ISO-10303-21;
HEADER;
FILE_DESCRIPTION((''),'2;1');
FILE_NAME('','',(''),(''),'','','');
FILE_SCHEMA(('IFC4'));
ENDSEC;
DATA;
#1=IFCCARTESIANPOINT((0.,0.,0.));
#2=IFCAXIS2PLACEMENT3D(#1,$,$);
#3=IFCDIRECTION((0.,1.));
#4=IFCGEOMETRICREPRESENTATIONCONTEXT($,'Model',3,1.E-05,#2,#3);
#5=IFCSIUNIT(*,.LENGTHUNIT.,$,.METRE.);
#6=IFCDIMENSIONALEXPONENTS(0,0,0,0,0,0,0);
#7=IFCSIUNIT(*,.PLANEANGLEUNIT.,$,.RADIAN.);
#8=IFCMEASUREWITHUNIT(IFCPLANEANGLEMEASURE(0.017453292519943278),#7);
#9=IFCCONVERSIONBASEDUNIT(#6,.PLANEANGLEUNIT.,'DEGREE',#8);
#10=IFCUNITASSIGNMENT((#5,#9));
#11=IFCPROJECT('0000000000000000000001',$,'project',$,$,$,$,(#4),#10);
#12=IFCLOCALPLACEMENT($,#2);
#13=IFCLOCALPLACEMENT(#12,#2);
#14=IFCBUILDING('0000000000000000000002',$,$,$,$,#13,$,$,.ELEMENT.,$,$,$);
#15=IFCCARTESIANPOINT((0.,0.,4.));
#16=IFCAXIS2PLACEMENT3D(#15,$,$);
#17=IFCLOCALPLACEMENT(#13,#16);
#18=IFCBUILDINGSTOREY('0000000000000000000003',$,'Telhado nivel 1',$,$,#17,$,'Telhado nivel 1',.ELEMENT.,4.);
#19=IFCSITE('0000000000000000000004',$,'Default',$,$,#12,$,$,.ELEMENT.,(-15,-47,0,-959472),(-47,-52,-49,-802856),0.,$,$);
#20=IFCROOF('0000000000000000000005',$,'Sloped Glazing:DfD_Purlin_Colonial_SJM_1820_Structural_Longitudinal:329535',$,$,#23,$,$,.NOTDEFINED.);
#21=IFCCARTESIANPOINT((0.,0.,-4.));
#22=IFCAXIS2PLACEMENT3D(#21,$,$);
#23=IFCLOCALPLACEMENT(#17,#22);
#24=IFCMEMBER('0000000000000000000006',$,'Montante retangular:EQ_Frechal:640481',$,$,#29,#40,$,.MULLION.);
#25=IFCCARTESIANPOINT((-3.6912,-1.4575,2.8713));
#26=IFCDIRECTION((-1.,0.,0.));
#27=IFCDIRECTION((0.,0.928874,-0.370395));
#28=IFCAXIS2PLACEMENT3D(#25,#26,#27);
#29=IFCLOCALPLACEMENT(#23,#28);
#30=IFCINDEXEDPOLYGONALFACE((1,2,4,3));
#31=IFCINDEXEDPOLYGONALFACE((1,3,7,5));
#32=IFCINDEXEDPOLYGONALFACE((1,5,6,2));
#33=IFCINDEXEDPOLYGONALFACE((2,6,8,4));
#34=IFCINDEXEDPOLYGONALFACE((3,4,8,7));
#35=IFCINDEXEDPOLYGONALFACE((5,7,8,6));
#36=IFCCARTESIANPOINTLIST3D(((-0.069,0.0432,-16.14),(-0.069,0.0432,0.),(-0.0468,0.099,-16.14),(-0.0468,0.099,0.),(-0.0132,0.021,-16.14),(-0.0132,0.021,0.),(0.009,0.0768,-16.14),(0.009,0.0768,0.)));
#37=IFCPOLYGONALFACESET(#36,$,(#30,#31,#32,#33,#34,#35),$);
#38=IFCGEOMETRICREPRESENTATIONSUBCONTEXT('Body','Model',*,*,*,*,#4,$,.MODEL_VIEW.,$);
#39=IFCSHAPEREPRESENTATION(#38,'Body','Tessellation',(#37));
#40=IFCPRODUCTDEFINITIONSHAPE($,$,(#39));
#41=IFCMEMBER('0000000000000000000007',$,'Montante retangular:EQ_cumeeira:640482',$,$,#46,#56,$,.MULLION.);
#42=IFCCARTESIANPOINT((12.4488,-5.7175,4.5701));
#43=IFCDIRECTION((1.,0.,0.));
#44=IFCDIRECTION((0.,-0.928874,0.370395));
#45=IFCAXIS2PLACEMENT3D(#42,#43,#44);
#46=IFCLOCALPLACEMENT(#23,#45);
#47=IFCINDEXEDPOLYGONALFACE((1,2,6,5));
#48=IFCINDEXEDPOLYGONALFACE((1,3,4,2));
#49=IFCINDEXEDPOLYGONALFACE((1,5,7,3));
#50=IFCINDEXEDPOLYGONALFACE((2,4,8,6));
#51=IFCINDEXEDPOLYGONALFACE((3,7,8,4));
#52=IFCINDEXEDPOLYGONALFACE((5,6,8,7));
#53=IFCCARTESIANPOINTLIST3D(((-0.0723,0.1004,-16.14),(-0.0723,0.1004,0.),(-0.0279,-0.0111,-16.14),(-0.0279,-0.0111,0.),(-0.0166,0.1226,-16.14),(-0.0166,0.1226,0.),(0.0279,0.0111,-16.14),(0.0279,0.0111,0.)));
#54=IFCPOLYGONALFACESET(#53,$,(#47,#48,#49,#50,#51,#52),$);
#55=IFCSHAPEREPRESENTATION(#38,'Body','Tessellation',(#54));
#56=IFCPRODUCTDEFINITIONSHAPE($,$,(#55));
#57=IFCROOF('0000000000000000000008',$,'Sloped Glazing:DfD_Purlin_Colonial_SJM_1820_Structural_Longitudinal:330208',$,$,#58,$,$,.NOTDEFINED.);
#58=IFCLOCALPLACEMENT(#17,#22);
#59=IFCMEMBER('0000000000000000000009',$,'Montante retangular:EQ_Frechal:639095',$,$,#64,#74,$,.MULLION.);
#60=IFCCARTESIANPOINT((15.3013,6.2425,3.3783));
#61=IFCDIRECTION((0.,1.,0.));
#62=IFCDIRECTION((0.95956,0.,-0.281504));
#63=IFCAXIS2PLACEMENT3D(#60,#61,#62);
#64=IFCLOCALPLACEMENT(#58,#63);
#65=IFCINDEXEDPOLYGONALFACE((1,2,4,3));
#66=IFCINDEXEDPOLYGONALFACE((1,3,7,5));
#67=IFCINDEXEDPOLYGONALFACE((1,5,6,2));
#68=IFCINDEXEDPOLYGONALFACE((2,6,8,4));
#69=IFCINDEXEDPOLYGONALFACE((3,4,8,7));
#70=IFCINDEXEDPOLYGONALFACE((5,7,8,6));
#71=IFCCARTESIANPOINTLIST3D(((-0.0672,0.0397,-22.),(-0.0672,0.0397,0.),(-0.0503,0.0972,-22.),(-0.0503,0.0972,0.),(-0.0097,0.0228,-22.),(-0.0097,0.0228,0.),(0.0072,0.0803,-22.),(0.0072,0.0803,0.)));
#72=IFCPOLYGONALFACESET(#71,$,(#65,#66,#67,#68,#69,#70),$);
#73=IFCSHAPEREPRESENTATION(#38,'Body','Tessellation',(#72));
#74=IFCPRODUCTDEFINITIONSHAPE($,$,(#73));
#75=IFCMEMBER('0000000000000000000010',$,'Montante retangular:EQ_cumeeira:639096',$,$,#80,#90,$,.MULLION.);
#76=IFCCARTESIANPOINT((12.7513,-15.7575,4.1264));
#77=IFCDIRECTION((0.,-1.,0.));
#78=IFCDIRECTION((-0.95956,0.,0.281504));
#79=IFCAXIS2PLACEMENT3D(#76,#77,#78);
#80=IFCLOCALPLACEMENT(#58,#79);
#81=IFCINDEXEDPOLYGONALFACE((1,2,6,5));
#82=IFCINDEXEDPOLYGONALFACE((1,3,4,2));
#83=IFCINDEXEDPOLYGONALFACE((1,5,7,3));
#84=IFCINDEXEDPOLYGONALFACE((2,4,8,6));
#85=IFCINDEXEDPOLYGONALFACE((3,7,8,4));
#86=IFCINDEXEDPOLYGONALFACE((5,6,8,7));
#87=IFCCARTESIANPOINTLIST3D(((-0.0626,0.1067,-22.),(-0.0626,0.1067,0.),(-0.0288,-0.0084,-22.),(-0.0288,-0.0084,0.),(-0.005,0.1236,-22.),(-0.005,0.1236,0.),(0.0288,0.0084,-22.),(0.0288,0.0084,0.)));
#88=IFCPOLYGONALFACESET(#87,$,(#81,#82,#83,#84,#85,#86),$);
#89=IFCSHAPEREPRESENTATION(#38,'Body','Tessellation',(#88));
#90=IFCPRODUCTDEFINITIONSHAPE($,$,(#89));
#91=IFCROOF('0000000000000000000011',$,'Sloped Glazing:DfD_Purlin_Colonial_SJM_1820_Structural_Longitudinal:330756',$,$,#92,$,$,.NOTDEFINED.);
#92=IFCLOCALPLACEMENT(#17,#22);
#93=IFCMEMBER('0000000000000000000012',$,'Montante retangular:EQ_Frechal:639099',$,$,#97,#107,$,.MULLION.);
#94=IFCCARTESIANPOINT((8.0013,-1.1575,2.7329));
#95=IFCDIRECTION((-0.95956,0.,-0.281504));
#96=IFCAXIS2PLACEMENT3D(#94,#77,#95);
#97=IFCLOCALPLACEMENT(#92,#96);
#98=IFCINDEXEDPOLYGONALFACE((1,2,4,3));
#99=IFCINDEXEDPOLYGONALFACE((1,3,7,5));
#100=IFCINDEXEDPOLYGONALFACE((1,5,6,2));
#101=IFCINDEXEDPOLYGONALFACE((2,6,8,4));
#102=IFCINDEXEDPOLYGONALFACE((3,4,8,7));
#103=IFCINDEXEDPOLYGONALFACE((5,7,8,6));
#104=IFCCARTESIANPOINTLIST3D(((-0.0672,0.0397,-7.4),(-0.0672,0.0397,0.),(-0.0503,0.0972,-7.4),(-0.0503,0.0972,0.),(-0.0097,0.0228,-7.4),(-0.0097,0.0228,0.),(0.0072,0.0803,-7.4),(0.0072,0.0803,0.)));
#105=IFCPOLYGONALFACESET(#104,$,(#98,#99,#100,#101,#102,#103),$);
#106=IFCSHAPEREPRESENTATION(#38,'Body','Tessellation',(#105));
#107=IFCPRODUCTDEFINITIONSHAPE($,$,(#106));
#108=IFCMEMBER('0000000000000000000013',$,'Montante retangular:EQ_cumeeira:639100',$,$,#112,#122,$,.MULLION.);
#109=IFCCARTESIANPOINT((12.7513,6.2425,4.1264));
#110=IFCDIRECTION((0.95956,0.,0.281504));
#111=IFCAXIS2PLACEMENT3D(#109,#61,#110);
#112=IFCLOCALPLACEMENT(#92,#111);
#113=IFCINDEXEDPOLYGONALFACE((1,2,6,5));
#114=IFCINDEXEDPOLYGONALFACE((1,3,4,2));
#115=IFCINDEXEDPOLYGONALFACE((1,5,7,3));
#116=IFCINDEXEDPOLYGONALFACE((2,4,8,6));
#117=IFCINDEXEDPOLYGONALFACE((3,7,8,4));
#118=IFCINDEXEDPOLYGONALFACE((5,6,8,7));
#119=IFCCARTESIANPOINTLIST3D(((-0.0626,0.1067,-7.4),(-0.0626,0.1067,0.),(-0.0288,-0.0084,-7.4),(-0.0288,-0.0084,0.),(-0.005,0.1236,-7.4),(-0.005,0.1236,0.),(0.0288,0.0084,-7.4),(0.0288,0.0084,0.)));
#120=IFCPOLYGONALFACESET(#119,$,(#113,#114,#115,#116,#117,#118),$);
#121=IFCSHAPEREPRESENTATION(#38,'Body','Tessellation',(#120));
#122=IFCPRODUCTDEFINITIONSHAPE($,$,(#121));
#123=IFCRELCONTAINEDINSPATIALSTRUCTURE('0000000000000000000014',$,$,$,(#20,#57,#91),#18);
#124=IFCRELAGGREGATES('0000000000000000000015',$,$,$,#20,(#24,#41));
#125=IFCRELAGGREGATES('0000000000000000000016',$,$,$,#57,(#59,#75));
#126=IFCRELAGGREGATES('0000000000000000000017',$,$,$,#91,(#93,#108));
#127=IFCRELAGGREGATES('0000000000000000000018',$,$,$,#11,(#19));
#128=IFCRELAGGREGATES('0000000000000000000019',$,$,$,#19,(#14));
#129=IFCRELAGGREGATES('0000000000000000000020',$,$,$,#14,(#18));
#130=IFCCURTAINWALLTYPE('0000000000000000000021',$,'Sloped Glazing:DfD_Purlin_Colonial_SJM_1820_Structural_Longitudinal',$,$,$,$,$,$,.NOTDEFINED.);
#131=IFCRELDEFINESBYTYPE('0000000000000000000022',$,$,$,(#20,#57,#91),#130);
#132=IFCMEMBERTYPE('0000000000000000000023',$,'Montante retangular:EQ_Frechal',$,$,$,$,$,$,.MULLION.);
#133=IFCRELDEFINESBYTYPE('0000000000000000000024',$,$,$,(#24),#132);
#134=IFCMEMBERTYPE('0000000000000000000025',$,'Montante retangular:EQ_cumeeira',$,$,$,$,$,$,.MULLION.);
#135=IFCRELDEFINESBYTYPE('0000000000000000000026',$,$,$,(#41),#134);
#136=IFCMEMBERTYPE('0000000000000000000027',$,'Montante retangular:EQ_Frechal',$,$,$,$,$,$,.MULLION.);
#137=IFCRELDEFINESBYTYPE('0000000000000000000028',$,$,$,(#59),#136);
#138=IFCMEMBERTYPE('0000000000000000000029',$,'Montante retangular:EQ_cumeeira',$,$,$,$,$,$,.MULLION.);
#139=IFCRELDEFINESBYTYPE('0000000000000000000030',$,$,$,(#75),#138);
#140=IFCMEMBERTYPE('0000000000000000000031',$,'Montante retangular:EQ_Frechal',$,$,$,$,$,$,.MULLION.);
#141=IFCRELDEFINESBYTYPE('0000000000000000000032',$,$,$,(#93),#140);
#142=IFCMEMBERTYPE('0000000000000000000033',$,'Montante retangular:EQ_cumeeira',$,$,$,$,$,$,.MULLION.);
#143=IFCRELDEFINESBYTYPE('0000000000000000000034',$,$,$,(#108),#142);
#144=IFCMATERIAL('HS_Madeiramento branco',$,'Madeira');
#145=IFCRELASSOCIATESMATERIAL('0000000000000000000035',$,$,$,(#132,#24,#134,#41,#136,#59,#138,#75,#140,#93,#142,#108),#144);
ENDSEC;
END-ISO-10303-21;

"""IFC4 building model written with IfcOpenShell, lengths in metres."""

from ifc_helpers import new_model, entity, si_unit, converted_unit, direction, frame, origin, place, context, subcontext, project, spatial, indexed_curve, outline, extrude, source, transform, mapped, material, type_object, type_shapes, element, aggregate, save


model = new_model("IFC4")

# Units and contexts
model_context = context("Model", 3, precision=1e-05, world=origin(), true_north=direction((0.0, 1.0)))
body_context = subcontext(model_context, "Body", "Model", "MODEL_VIEW")
ifc_project = project(units=[si_unit("LENGTHUNIT", "METRE"), converted_unit("PLANEANGLEUNIT", "DEGREE", entity("IfcPlaneAngleMeasure", 0.017453292519943278), si_unit("PLANEANGLEUNIT", "RADIAN"), dimensions=[0, 0, 0, 0, 0, 0, 0])], contexts=[model_context])

# Site, building, storey
site_placement = place(None, origin())
site = spatial("IfcSite", under=ifc_project, at=site_placement, Name="Default", CompositionType="ELEMENT", RefLatitude=(-15, -47, 0, -959472), RefLongitude=(-47, -52, -49, -802856), RefElevation=0.0)
building_placement = place(site_placement, origin())
building = spatial("IfcBuilding", under=site, at=building_placement, CompositionType="ELEMENT")
storey_placement = place(building_placement, frame((0.0, 0.0, 4.0)))
storey = spatial("IfcBuildingStorey", under=building, at=storey_placement, Name="Telhado nivel 1", LongName="Telhado nivel 1", CompositionType="ELEMENT", Elevation=4.0)

# Roofs, members
curtain_wall_type = type_object("IfcCurtainWallType", Name="Sloped Glazing:DfD_Purlin_Colonial_SJM_1820_Structural_Longitudinal", PredefinedType="NOTDEFINED")
roof_1_placement = place(storey_placement, frame((0.0, 0.0, -4.0)))
roof_1 = element("IfcRoof", 1, at=roof_1_placement, inside=storey, type_object=curtain_wall_type, Name="Sloped Glazing:DfD_Purlin_Colonial_SJM_1820_Structural_Longitudinal:329535", PredefinedType="NOTDEFINED")
ifc_material = material(Name="HS_Madeiramento branco", Category="Madeira")
member_type_1 = type_object("IfcMemberType", Name="Montante retangular:EQ_Frechal", PredefinedType="MULLION", material=ifc_material)
shared_shape_1 = source(origin(), body_context, "Body", "SweptSolid", [
    extrude(outline(indexed_curve([(-0.03, -0.03), (0.03, -0.03), (0.03, 0.03), (-0.03, 0.03), (-0.03, -0.03)], self_intersect=False)), frame((-0.03, 0.06, -16.14), z_axis=(0.0, 0.0, 1.0), x_axis=(0.928874, -0.370395, 0.0)), (0.0, 0.0, 1.0), 16.14),
])
type_shapes(member_type_1, [shared_shape_1])
member_1_placement = place(roof_1_placement, frame((-3.6912, -1.4575, 2.8713), z_axis=(-1.0, 0.0, 0.0), x_axis=(0.0, 0.928874, -0.370395)))
member_1 = element("IfcMember", 2, at=member_1_placement, type_object=member_type_1, material=ifc_material, Name="Montante retangular:EQ_Frechal:640481", PredefinedType="MULLION", context=body_context, shape_type="MappedRepresentation", body=[
    mapped(shared_shape_1, transform((0.0, 0.0, 0.0), scale=1.0)),
])
member_type_2 = type_object("IfcMemberType", Name="Montante retangular:EQ_cumeeira", PredefinedType="MULLION", material=ifc_material)
shared_shape_2 = source(origin(), body_context, "Body", "SweptSolid", [
    extrude(outline(indexed_curve([(-0.06, -0.03), (0.06, -0.03), (0.06, 0.03), (-0.06, 0.03), (-0.06, -0.03)], self_intersect=False)), frame((-0.0222, 0.0557, -16.14), z_axis=(0.0, 0.0, 1.0), x_axis=(-0.370395, 0.928874, 0.0)), (0.0, 0.0, 1.0), 16.14),
])
type_shapes(member_type_2, [shared_shape_2])
member_2_placement = place(roof_1_placement, frame((12.4488, -5.7175, 4.5701), z_axis=(1.0, 0.0, 0.0), x_axis=(0.0, -0.928874, 0.370395)))
member_2 = element("IfcMember", 3, at=member_2_placement, type_object=member_type_2, material=ifc_material, Name="Montante retangular:EQ_cumeeira:640482", PredefinedType="MULLION", context=body_context, shape_type="MappedRepresentation", body=[
    mapped(shared_shape_2, transform((0.0, 0.0, 0.0), scale=1.0)),
])
aggregate(roof_1, [member_1, member_2])
roof_2_placement = place(storey_placement, frame((0.0, 0.0, -4.0)))
roof_2 = element("IfcRoof", 4, at=roof_2_placement, inside=storey, type_object=curtain_wall_type, Name="Sloped Glazing:DfD_Purlin_Colonial_SJM_1820_Structural_Longitudinal:330208", PredefinedType="NOTDEFINED")
member_type_3 = type_object("IfcMemberType", Name="Montante retangular:EQ_Frechal", PredefinedType="MULLION", material=ifc_material)
shared_shape_3 = source(origin(), body_context, "Body", "SweptSolid", [
    extrude(outline(indexed_curve([(-0.03, -0.03), (0.03, -0.03), (0.03, 0.03), (-0.03, 0.03), (-0.03, -0.03)], self_intersect=False)), frame((-0.03, 0.06, -22.0), z_axis=(0.0, 0.0, 1.0), x_axis=(0.95956, -0.281504, 0.0)), (0.0, 0.0, 1.0), 22.0),
])
type_shapes(member_type_3, [shared_shape_3])
member_3_placement = place(roof_2_placement, frame((15.3013, 6.2425, 3.3783), z_axis=(0.0, 1.0, 0.0), x_axis=(0.95956, 0.0, -0.281504)))
member_3 = element("IfcMember", 5, at=member_3_placement, type_object=member_type_3, material=ifc_material, Name="Montante retangular:EQ_Frechal:639095", PredefinedType="MULLION", context=body_context, shape_type="MappedRepresentation", body=[
    mapped(shared_shape_3, transform((0.0, 0.0, 0.0), scale=1.0)),
])
member_type_4 = type_object("IfcMemberType", Name="Montante retangular:EQ_cumeeira", PredefinedType="MULLION", material=ifc_material)
shared_shape_4 = source(origin(), body_context, "Body", "SweptSolid", [
    extrude(outline(indexed_curve([(-0.06, -0.03), (0.06, -0.03), (0.06, 0.03), (-0.06, 0.03), (-0.06, -0.03)], self_intersect=False)), frame((-0.0169, 0.0576, -22.0), z_axis=(0.0, 0.0, 1.0), x_axis=(-0.281504, 0.95956, 0.0)), (0.0, 0.0, 1.0), 22.0),
])
type_shapes(member_type_4, [shared_shape_4])
member_4_placement = place(roof_2_placement, frame((12.7513, -15.7575, 4.1264), z_axis=(0.0, -1.0, 0.0), x_axis=(-0.95956, 0.0, 0.281504)))
member_4 = element("IfcMember", 6, at=member_4_placement, type_object=member_type_4, material=ifc_material, Name="Montante retangular:EQ_cumeeira:639096", PredefinedType="MULLION", context=body_context, shape_type="MappedRepresentation", body=[
    mapped(shared_shape_4, transform((0.0, 0.0, 0.0), scale=1.0)),
])
aggregate(roof_2, [member_3, member_4])
roof_3_placement = place(storey_placement, frame((0.0, 0.0, -4.0)))
roof_3 = element("IfcRoof", 7, at=roof_3_placement, inside=storey, type_object=curtain_wall_type, Name="Sloped Glazing:DfD_Purlin_Colonial_SJM_1820_Structural_Longitudinal:330756", PredefinedType="NOTDEFINED")
member_type_5 = type_object("IfcMemberType", Name="Montante retangular:EQ_Frechal", PredefinedType="MULLION", material=ifc_material)
shared_shape_5 = source(origin(), body_context, "Body", "SweptSolid", [
    extrude(outline(indexed_curve([(-0.03, -0.03), (0.03, -0.03), (0.03, 0.03), (-0.03, 0.03), (-0.03, -0.03)], self_intersect=False)), frame((-0.03, 0.06, -7.4), z_axis=(0.0, 0.0, 1.0), x_axis=(0.95956, -0.281504, 0.0)), (0.0, 0.0, 1.0), 7.4),
])
type_shapes(member_type_5, [shared_shape_5])
member_5_placement = place(roof_3_placement, frame((8.0013, -1.1575, 2.7329), z_axis=(0.0, -1.0, 0.0), x_axis=(-0.95956, 0.0, -0.281504)))
member_5 = element("IfcMember", 8, at=member_5_placement, type_object=member_type_5, material=ifc_material, Name="Montante retangular:EQ_Frechal:639099", PredefinedType="MULLION", context=body_context, shape_type="MappedRepresentation", body=[
    mapped(shared_shape_5, transform((0.0, 0.0, 0.0), scale=1.0)),
])
member_type_6 = type_object("IfcMemberType", Name="Montante retangular:EQ_cumeeira", PredefinedType="MULLION", material=ifc_material)
shared_shape_6 = source(origin(), body_context, "Body", "SweptSolid", [
    extrude(outline(indexed_curve([(-0.06, -0.03), (0.06, -0.03), (0.06, 0.03), (-0.06, 0.03), (-0.06, -0.03)], self_intersect=False)), frame((-0.0169, 0.0576, -7.4), z_axis=(0.0, 0.0, 1.0), x_axis=(-0.281504, 0.95956, 0.0)), (0.0, 0.0, 1.0), 7.4),
])
type_shapes(member_type_6, [shared_shape_6])
member_6_placement = place(roof_3_placement, frame((12.7513, 6.2425, 4.1264), z_axis=(0.0, 1.0, 0.0), x_axis=(0.95956, 0.0, 0.281504)))
member_6 = element("IfcMember", 9, at=member_6_placement, type_object=member_type_6, material=ifc_material, Name="Montante retangular:EQ_cumeeira:639100", PredefinedType="MULLION", context=body_context, shape_type="MappedRepresentation", body=[
    mapped(shared_shape_6, transform((0.0, 0.0, 0.0), scale=1.0)),
])
aggregate(roof_3, [member_5, member_6])

save(model, "model.ifc")
